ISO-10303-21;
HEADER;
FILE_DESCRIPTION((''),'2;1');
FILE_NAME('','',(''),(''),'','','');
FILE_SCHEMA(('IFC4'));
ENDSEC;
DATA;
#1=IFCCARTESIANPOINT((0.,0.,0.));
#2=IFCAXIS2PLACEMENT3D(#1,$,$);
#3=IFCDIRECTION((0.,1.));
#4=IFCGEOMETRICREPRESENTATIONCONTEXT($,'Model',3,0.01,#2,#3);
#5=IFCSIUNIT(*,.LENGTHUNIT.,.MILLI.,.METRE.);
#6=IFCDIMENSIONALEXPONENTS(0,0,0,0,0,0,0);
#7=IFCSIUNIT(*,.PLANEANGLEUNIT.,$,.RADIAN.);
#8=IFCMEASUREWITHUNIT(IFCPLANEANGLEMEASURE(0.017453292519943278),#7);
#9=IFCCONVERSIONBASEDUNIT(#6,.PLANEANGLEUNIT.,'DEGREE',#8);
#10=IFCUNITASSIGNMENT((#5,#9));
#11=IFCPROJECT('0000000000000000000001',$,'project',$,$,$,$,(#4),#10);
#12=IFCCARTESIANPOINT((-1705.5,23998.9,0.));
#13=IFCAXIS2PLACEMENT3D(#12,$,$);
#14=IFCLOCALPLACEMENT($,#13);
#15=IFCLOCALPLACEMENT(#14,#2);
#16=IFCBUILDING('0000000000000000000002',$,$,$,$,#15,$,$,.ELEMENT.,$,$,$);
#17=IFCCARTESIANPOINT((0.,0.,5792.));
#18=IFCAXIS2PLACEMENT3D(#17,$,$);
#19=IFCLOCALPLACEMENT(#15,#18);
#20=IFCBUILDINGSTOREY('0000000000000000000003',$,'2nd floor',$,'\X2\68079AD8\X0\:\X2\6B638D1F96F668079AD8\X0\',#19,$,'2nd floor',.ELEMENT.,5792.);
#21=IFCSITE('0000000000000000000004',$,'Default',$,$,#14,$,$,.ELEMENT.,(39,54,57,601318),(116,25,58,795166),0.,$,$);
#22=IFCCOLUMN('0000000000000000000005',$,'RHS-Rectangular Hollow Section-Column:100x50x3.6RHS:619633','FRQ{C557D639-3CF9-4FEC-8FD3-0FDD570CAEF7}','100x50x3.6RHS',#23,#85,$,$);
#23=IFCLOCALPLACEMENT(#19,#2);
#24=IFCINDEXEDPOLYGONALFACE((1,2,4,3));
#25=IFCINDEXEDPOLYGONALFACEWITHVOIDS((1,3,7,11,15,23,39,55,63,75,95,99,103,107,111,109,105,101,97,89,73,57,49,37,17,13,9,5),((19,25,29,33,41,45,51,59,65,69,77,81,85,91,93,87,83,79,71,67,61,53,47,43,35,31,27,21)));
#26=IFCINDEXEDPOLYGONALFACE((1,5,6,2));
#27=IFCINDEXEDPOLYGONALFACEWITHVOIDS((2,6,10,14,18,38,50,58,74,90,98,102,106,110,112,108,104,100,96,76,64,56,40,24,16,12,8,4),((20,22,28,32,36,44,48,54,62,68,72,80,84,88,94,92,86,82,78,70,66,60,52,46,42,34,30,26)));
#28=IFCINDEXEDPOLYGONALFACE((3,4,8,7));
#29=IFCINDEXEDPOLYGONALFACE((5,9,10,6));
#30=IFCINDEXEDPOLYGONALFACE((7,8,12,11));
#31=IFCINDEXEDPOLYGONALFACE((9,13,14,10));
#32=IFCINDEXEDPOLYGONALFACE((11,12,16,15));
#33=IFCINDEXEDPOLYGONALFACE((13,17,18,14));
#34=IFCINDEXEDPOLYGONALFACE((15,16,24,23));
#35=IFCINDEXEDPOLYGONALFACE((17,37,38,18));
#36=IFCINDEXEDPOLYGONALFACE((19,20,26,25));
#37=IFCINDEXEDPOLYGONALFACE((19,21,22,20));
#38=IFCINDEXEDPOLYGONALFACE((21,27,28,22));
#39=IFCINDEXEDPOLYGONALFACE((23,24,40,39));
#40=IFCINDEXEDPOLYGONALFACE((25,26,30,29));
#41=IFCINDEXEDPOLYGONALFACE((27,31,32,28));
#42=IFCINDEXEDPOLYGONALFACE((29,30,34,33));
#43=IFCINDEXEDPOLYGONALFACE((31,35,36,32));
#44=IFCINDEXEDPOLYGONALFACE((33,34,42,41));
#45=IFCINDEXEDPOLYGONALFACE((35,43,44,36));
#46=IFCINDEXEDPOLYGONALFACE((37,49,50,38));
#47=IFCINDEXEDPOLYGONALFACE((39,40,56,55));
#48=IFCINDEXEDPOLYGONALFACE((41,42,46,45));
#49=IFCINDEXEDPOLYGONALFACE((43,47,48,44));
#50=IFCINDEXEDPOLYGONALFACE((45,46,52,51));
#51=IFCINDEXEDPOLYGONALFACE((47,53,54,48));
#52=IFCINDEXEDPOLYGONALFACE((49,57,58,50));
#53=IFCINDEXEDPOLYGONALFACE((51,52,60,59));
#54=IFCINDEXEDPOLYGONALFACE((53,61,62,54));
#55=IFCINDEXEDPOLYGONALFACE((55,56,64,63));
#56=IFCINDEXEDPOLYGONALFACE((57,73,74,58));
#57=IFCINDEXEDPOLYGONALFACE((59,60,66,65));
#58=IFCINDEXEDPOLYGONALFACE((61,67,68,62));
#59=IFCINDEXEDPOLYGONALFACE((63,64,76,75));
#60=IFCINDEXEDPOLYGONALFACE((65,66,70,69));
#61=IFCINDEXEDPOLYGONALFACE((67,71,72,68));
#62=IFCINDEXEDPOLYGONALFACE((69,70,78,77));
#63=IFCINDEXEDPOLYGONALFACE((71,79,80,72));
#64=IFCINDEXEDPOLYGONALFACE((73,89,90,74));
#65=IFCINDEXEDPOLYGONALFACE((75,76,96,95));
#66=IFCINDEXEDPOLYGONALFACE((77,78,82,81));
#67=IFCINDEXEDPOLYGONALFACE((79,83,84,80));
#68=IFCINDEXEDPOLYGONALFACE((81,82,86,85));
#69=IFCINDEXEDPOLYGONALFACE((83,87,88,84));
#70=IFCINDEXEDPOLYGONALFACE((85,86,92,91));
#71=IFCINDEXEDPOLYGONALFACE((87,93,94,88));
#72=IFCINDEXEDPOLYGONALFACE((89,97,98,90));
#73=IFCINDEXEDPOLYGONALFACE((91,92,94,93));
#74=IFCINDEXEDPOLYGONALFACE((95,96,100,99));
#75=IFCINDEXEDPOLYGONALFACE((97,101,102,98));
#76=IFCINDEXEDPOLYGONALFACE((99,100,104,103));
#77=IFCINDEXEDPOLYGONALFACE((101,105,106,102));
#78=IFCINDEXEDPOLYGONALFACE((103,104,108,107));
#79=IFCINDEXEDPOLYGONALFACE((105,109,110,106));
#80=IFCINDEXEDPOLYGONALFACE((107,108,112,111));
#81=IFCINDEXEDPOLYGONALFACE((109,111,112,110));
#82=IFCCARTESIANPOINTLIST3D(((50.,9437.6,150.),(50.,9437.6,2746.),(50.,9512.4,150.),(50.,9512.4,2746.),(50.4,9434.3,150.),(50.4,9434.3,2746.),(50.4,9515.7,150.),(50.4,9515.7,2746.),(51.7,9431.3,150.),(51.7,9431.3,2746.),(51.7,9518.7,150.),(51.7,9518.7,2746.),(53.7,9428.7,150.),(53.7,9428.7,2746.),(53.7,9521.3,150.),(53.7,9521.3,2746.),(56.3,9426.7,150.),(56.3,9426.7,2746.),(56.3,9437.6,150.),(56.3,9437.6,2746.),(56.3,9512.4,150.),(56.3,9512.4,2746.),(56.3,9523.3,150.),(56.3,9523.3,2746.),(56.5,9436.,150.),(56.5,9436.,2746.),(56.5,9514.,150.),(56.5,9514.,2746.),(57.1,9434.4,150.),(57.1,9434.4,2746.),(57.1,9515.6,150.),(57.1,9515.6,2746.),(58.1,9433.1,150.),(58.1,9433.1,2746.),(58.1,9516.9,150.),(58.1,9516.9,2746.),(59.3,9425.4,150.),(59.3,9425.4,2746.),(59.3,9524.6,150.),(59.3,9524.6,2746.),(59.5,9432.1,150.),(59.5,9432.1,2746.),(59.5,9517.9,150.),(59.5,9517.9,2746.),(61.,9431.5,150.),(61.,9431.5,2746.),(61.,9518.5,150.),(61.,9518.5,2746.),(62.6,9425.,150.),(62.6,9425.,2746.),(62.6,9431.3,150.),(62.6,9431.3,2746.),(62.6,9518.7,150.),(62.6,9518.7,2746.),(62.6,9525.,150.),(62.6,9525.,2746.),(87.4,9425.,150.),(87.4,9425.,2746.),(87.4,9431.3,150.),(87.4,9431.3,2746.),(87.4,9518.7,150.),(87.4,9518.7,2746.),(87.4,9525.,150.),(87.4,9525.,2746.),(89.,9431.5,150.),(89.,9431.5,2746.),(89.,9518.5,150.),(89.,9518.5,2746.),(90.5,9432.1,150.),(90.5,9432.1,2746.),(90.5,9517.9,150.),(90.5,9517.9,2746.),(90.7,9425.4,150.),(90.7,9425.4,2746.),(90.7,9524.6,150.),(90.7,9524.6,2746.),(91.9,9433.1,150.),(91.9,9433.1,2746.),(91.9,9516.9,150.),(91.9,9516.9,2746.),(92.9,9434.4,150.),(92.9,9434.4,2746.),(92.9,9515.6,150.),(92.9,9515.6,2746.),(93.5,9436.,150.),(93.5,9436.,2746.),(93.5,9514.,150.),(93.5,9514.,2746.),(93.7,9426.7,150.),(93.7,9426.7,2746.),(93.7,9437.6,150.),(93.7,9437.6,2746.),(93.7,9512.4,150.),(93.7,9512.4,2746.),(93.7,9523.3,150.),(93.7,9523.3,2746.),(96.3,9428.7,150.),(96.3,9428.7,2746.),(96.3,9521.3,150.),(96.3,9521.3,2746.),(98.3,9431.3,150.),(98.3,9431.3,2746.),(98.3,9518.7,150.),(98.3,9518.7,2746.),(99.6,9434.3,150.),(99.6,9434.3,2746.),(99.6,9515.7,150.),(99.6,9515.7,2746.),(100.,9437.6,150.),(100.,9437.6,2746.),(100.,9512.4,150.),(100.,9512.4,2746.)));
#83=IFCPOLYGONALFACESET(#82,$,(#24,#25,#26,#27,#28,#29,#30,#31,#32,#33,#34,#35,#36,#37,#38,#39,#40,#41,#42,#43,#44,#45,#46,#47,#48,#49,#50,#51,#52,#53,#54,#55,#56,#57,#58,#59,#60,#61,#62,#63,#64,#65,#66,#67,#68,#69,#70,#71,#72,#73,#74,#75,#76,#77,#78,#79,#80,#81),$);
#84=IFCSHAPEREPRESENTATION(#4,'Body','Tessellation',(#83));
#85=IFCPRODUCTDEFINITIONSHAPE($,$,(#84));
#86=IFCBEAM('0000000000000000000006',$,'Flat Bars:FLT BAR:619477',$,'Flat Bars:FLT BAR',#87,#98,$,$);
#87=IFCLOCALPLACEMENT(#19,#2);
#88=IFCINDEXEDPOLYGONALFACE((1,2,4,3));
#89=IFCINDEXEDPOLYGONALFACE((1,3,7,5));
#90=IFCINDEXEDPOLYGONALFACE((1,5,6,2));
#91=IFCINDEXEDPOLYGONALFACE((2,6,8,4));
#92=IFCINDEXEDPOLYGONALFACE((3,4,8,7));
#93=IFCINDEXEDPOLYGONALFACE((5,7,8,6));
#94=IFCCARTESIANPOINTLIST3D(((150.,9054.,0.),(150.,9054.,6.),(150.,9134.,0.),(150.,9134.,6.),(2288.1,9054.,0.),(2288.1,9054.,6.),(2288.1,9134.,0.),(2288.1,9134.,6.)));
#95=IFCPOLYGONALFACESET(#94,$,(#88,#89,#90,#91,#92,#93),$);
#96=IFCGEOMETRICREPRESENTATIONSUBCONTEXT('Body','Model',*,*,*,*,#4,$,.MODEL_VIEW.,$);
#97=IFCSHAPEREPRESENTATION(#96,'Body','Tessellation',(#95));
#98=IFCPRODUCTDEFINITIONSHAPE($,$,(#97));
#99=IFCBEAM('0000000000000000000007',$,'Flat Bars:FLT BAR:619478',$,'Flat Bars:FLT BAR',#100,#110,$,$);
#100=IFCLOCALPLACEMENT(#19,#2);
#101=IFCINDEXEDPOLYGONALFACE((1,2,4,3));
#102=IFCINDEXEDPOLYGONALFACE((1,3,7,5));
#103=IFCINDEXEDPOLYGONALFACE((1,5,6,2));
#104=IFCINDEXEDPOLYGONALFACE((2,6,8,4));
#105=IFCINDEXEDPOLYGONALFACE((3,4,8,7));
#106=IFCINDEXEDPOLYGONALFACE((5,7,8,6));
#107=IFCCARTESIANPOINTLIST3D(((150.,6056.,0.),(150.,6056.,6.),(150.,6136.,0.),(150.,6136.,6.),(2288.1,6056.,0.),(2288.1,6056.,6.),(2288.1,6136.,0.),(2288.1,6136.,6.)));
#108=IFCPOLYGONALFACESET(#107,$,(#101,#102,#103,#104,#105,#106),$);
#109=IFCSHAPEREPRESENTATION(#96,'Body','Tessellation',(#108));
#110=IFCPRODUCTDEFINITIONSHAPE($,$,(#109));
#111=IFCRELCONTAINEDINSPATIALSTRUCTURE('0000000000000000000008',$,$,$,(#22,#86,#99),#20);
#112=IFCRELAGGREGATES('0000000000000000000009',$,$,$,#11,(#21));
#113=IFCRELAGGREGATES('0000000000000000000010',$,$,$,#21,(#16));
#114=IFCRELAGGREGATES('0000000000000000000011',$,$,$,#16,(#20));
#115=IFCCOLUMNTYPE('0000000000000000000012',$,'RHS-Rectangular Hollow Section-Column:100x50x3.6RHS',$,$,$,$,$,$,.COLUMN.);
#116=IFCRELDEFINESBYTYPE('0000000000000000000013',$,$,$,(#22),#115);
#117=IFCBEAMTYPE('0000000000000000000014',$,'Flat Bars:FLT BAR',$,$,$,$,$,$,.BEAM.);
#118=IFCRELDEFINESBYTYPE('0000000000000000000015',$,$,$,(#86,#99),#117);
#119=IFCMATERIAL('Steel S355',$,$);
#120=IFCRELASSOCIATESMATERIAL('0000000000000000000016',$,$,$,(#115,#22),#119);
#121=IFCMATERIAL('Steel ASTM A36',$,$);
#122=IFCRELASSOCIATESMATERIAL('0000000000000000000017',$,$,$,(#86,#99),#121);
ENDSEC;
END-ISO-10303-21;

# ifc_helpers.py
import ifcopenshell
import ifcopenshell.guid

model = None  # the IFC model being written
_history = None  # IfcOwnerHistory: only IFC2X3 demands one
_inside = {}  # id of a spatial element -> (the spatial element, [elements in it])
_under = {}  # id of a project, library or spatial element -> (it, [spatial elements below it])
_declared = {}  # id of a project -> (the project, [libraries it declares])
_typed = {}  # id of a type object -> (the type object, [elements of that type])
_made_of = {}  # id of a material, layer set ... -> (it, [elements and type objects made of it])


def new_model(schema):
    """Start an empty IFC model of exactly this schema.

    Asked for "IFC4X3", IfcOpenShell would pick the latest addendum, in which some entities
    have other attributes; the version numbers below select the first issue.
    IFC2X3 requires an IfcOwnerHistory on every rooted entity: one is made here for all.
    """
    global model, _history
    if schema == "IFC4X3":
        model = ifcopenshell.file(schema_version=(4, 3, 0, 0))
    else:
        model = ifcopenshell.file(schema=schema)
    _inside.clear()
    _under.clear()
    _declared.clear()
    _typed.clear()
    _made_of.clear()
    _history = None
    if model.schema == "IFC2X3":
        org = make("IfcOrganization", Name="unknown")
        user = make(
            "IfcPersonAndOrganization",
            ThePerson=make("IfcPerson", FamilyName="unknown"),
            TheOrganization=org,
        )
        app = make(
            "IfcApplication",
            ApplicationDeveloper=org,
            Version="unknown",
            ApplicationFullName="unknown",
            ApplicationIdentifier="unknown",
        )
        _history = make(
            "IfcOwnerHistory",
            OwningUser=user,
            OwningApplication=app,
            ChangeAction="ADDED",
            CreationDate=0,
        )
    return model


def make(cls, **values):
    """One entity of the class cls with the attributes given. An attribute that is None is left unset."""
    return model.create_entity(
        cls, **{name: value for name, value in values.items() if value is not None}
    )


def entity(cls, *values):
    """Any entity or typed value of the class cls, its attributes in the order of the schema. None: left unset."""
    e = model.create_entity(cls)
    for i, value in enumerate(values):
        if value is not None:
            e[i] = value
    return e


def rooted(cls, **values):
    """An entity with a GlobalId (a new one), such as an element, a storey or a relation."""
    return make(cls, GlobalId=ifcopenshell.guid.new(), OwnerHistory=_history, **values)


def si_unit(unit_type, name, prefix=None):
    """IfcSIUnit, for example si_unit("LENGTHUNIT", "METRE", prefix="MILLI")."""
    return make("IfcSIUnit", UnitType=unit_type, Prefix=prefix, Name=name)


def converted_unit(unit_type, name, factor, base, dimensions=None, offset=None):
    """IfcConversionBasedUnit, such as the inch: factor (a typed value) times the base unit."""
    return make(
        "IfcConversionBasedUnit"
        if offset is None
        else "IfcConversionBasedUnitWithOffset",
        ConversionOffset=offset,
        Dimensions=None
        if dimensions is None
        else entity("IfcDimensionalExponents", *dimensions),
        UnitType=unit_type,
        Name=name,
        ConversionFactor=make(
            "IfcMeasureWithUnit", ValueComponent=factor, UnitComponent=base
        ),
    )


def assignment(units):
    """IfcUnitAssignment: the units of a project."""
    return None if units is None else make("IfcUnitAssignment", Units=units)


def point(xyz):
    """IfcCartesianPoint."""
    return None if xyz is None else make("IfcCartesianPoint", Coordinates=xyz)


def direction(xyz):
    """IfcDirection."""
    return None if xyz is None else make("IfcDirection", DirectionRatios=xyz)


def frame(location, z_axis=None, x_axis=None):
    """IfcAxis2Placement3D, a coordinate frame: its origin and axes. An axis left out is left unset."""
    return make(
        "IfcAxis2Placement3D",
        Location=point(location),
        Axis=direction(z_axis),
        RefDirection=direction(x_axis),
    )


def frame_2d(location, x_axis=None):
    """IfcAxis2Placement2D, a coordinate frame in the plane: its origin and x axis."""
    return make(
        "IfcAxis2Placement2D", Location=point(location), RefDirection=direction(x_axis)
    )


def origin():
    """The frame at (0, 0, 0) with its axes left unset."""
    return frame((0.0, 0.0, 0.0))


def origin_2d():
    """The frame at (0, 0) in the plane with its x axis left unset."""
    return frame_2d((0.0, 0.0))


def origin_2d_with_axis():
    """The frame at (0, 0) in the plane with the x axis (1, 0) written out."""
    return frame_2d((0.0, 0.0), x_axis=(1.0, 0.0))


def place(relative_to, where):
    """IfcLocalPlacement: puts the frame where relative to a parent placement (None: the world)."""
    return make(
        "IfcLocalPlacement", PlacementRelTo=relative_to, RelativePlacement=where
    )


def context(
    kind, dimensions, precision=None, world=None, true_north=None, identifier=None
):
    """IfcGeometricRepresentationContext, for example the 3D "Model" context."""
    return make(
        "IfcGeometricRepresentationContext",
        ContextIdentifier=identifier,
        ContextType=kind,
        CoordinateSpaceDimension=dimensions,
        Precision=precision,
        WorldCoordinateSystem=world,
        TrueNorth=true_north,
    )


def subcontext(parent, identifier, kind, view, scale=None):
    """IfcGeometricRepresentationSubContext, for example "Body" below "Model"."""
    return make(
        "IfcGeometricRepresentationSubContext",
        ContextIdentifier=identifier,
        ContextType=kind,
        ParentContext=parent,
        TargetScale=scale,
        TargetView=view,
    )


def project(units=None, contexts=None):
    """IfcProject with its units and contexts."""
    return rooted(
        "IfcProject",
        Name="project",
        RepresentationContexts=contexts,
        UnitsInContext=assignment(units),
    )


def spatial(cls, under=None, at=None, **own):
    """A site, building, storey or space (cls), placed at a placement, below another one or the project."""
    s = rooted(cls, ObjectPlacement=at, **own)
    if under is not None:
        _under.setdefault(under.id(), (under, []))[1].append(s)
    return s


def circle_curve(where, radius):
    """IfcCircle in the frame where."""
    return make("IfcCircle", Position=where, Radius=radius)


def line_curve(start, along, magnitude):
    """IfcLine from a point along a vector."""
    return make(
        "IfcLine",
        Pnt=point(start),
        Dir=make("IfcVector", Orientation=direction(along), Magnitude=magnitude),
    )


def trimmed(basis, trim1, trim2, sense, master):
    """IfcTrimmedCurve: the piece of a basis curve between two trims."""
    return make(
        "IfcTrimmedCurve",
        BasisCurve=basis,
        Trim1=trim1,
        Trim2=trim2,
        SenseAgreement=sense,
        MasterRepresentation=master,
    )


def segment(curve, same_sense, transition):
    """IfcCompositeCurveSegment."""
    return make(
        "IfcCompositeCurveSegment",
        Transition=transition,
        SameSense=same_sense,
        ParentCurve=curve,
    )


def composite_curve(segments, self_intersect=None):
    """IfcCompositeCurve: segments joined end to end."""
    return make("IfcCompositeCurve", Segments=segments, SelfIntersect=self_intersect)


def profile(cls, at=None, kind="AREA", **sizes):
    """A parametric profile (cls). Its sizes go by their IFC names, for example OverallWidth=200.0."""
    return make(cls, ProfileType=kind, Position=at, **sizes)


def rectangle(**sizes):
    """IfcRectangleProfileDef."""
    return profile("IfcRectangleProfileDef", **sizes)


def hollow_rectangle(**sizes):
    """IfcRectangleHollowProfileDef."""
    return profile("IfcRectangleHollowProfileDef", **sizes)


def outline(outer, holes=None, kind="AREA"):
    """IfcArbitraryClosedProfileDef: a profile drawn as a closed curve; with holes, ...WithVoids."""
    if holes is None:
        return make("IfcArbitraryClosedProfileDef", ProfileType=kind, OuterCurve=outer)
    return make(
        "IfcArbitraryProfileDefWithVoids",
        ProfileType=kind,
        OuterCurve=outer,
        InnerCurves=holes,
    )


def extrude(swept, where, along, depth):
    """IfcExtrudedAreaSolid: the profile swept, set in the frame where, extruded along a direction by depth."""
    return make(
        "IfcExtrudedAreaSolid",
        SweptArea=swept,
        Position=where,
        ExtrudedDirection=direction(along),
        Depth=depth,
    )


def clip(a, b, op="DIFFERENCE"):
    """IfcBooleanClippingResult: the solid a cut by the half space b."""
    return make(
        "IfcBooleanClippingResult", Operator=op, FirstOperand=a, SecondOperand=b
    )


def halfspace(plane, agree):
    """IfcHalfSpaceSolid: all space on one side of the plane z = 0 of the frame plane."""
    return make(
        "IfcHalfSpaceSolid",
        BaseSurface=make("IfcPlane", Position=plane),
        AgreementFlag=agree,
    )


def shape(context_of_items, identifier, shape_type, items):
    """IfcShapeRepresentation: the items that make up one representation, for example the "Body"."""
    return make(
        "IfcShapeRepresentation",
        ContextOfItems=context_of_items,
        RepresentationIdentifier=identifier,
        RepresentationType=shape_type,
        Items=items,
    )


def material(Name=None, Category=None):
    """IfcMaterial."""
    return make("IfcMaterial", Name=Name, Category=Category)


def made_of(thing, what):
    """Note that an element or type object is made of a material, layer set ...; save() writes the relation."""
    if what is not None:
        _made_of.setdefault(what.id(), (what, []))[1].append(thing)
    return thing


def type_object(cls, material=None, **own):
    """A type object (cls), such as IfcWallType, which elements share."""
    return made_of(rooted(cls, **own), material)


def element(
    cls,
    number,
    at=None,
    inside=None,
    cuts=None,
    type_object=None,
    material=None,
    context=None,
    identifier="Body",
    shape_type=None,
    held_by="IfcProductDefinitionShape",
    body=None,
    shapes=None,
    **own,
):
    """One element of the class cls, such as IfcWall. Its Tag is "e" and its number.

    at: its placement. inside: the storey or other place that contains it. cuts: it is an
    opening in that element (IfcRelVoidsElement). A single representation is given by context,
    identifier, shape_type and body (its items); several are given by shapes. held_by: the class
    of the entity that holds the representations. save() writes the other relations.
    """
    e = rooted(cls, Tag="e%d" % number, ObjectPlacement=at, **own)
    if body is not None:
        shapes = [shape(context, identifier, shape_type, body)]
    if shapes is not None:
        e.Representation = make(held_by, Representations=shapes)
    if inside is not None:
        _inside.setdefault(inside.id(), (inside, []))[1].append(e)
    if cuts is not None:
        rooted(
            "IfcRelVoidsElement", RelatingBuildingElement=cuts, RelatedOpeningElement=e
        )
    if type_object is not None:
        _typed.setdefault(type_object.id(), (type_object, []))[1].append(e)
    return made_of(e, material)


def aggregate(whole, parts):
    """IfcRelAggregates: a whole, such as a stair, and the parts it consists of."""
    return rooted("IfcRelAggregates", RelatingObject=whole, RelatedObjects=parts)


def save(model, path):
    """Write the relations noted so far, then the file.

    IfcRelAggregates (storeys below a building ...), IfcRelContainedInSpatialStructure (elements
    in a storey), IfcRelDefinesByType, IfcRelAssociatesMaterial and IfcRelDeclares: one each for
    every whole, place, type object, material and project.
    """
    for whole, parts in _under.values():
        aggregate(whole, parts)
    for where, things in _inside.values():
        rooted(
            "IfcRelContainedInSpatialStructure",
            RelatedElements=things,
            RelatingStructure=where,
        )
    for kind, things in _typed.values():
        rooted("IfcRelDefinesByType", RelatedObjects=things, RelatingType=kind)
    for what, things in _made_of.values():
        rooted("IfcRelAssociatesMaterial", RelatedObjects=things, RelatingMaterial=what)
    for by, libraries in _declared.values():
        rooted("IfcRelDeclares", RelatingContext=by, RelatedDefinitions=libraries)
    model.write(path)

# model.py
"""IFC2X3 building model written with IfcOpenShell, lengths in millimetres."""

from ifc_helpers import new_model, entity, si_unit, converted_unit, point, direction, frame, frame_2d, origin, origin_2d, origin_2d_with_axis, place, context, subcontext, project, spatial, circle_curve, line_curve, trimmed, segment, composite_curve, rectangle, hollow_rectangle, outline, extrude, clip, halfspace, material, type_object, element, save


model = new_model("IFC2X3")

# Units and contexts
model_context = context("Model", 3, precision=0.01, world=origin(), true_north=direction((0.0, 1.0)))
body_context = subcontext(model_context, "Body", "Model", "MODEL_VIEW")
ifc_project = project(units=[si_unit("LENGTHUNIT", "METRE", prefix="MILLI"), converted_unit("PLANEANGLEUNIT", "DEGREE", entity("IfcPlaneAngleMeasure", 0.017453292519943278), si_unit("PLANEANGLEUNIT", "RADIAN"), dimensions=[0, 0, 0, 0, 0, 0, 0])], contexts=[model_context])

# Site, building, storey
site_placement = place(None, frame((-1705.5, 23998.9, 0.0)))
site = spatial("IfcSite", under=ifc_project, at=site_placement, Name="Default", CompositionType="ELEMENT", RefLatitude=(39, 54, 57, 601318), RefLongitude=(116, 25, 58, 795166), RefElevation=0.0)
building_placement = place(site_placement, origin())
building = spatial("IfcBuilding", under=site, at=building_placement, CompositionType="ELEMENT")
storey_placement = place(building_placement, frame((0.0, 0.0, 5792.0)))
storey = spatial("IfcBuildingStorey", under=building, at=storey_placement, Name="2nd floor", ObjectType="标高:正负零标高", LongName="2nd floor", CompositionType="ELEMENT", Elevation=5792.0)

# Shared definitions
ifc_material_1 = material(Name="Steel S355")
column_type = type_object("IfcColumnType", Name="RHS-Rectangular Hollow Section-Column:100x50x3.6RHS", PredefinedType="COLUMN", material=ifc_material_1)

# Column, opening
column_1_placement = place(storey_placement, frame((75.0, 9475.0, 2876.9)))
column_1 = element("IfcColumn", 1, at=column_1_placement, inside=storey, type_object=column_type, material=ifc_material_1, Name="RHS-Rectangular Hollow Section-Column:100x50x3.6RHS:619633", Description="FRQ{C557D639-3CF9-4FEC-8FD3-0FDD570CAEF7}", ObjectType="100x50x3.6RHS", context=model_context, shape_type="Clipping", body=[
    clip(clip(extrude(hollow_rectangle(XDim=50.0, YDim=100.0, WallThickness=6.3, InnerFilletRadius=6.3, OuterFilletRadius=12.6, at=origin_2d()), origin(), (0.0, 0.0, -1.0), 2782.8), halfspace(frame((-75.0, -9475.0, -55.9), z_axis=(0.0, 0.0, -1.0), x_axis=(-1.0, 0.0, 0.0)), True)), halfspace(frame((-75.0, -9475.0, -2726.9), z_axis=(0.0, 0.0, 1.0), x_axis=(1.0, 0.0, 0.0)), True)),
])
opening_1_placement = place(column_1_placement, frame((0.0, -150.1, -130.9), z_axis=(0.0, 1.0, 0.0), x_axis=(-1.0, 0.0, 0.0)))
element("IfcOpeningElement", 2, at=opening_1_placement, cuts=column_1, ObjectType="Opening", context=model_context, shape_type="SweptSolid", body=[
    extrude(outline(composite_curve([segment(trimmed(circle_curve(frame_2d((43.0, 32.0), x_axis=(1.0, 0.0)), 32.0), [point((43.0, 0.0))], [point((75.0, 32.0))], True, "CARTESIAN"), True, "CONTINUOUS"), segment(trimmed(line_curve((75.0, 32.0), (0.0, 1.0), 86.0), [point((75.0, 32.0))], [point((75.0, 118.0))], True, "CARTESIAN"), True, "CONTINUOUS"), segment(trimmed(circle_curve(frame_2d((43.0, 118.0), x_axis=(1.0, 0.0)), 32.0), [point((75.0, 118.0))], [point((43.0, 150.0))], True, "CARTESIAN"), True, "CONTINUOUS"), segment(trimmed(line_curve((43.0, 150.0), (-1.0, 0.0), 86.0), [point((43.0, 150.0))], [point((-43.0, 150.0))], True, "CARTESIAN"), True, "CONTINUOUS"), segment(trimmed(circle_curve(frame_2d((-43.0, 118.0), x_axis=(1.0, 0.0)), 32.0), [point((-43.0, 150.0))], [point((-75.0, 118.0))], True, "CARTESIAN"), True, "CONTINUOUS"), segment(trimmed(line_curve((-75.0, 118.0), (0.0, -1.0), 86.0), [point((-75.0, 118.0))], [point((-75.0, 32.0))], True, "CARTESIAN"), True, "CONTINUOUS"), segment(trimmed(circle_curve(frame_2d((-43.0, 32.0), x_axis=(1.0, 0.0)), 32.0), [point((-75.0, 32.0))], [point((-43.0, 0.0))], True, "CARTESIAN"), True, "CONTINUOUS"), segment(trimmed(line_curve((-43.0, 0.0), (1.0, 0.0), 86.0), [point((-43.0, 0.0))], [point((43.0, 0.0))], True, "CARTESIAN"), True, "CONTINUOUS")], self_intersect="UNKNOWN")), origin(), (0.0, 0.0, 1.0), 300.2),
])

# Beams
ifc_material_2 = material(Name="Steel ASTM A36")
beam_type = type_object("IfcBeamType", Name="Flat Bars:FLT BAR", PredefinedType="BEAM")
beam_1_placement = place(storey_placement, frame((150.0, 9094.0, 6.0)))
element("IfcBeam", 3, at=beam_1_placement, inside=storey, type_object=beam_type, material=ifc_material_2, Name="Flat Bars:FLT BAR:619477", ObjectType="Flat Bars:FLT BAR", context=body_context, shape_type="SweptSolid", body=[
    extrude(rectangle(XDim=6.0, YDim=80.0, at=frame_2d((0.0, 0.0), x_axis=(1.0, 0.0))), frame((0.0, 0.0, -3.0), z_axis=(1.0, 0.0, 0.0), x_axis=(0.0, 0.0, -1.0)), (0.0, 0.0, 1.0), 2138.1),
])
beam_2_placement = place(storey_placement, frame((150.0, 6096.0, 6.0)))
element("IfcBeam", 4, at=beam_2_placement, inside=storey, type_object=beam_type, material=ifc_material_2, Name="Flat Bars:FLT BAR:619478", ObjectType="Flat Bars:FLT BAR", context=body_context, shape_type="SweptSolid", body=[
    extrude(rectangle(XDim=6.0, YDim=80.0, at=origin_2d_with_axis()), frame((0.0, 0.0, -3.0), z_axis=(1.0, 0.0, 0.0), x_axis=(0.0, 0.0, -1.0)), (0.0, 0.0, 1.0), 2138.1),
])

save(model, "model.ifc")
